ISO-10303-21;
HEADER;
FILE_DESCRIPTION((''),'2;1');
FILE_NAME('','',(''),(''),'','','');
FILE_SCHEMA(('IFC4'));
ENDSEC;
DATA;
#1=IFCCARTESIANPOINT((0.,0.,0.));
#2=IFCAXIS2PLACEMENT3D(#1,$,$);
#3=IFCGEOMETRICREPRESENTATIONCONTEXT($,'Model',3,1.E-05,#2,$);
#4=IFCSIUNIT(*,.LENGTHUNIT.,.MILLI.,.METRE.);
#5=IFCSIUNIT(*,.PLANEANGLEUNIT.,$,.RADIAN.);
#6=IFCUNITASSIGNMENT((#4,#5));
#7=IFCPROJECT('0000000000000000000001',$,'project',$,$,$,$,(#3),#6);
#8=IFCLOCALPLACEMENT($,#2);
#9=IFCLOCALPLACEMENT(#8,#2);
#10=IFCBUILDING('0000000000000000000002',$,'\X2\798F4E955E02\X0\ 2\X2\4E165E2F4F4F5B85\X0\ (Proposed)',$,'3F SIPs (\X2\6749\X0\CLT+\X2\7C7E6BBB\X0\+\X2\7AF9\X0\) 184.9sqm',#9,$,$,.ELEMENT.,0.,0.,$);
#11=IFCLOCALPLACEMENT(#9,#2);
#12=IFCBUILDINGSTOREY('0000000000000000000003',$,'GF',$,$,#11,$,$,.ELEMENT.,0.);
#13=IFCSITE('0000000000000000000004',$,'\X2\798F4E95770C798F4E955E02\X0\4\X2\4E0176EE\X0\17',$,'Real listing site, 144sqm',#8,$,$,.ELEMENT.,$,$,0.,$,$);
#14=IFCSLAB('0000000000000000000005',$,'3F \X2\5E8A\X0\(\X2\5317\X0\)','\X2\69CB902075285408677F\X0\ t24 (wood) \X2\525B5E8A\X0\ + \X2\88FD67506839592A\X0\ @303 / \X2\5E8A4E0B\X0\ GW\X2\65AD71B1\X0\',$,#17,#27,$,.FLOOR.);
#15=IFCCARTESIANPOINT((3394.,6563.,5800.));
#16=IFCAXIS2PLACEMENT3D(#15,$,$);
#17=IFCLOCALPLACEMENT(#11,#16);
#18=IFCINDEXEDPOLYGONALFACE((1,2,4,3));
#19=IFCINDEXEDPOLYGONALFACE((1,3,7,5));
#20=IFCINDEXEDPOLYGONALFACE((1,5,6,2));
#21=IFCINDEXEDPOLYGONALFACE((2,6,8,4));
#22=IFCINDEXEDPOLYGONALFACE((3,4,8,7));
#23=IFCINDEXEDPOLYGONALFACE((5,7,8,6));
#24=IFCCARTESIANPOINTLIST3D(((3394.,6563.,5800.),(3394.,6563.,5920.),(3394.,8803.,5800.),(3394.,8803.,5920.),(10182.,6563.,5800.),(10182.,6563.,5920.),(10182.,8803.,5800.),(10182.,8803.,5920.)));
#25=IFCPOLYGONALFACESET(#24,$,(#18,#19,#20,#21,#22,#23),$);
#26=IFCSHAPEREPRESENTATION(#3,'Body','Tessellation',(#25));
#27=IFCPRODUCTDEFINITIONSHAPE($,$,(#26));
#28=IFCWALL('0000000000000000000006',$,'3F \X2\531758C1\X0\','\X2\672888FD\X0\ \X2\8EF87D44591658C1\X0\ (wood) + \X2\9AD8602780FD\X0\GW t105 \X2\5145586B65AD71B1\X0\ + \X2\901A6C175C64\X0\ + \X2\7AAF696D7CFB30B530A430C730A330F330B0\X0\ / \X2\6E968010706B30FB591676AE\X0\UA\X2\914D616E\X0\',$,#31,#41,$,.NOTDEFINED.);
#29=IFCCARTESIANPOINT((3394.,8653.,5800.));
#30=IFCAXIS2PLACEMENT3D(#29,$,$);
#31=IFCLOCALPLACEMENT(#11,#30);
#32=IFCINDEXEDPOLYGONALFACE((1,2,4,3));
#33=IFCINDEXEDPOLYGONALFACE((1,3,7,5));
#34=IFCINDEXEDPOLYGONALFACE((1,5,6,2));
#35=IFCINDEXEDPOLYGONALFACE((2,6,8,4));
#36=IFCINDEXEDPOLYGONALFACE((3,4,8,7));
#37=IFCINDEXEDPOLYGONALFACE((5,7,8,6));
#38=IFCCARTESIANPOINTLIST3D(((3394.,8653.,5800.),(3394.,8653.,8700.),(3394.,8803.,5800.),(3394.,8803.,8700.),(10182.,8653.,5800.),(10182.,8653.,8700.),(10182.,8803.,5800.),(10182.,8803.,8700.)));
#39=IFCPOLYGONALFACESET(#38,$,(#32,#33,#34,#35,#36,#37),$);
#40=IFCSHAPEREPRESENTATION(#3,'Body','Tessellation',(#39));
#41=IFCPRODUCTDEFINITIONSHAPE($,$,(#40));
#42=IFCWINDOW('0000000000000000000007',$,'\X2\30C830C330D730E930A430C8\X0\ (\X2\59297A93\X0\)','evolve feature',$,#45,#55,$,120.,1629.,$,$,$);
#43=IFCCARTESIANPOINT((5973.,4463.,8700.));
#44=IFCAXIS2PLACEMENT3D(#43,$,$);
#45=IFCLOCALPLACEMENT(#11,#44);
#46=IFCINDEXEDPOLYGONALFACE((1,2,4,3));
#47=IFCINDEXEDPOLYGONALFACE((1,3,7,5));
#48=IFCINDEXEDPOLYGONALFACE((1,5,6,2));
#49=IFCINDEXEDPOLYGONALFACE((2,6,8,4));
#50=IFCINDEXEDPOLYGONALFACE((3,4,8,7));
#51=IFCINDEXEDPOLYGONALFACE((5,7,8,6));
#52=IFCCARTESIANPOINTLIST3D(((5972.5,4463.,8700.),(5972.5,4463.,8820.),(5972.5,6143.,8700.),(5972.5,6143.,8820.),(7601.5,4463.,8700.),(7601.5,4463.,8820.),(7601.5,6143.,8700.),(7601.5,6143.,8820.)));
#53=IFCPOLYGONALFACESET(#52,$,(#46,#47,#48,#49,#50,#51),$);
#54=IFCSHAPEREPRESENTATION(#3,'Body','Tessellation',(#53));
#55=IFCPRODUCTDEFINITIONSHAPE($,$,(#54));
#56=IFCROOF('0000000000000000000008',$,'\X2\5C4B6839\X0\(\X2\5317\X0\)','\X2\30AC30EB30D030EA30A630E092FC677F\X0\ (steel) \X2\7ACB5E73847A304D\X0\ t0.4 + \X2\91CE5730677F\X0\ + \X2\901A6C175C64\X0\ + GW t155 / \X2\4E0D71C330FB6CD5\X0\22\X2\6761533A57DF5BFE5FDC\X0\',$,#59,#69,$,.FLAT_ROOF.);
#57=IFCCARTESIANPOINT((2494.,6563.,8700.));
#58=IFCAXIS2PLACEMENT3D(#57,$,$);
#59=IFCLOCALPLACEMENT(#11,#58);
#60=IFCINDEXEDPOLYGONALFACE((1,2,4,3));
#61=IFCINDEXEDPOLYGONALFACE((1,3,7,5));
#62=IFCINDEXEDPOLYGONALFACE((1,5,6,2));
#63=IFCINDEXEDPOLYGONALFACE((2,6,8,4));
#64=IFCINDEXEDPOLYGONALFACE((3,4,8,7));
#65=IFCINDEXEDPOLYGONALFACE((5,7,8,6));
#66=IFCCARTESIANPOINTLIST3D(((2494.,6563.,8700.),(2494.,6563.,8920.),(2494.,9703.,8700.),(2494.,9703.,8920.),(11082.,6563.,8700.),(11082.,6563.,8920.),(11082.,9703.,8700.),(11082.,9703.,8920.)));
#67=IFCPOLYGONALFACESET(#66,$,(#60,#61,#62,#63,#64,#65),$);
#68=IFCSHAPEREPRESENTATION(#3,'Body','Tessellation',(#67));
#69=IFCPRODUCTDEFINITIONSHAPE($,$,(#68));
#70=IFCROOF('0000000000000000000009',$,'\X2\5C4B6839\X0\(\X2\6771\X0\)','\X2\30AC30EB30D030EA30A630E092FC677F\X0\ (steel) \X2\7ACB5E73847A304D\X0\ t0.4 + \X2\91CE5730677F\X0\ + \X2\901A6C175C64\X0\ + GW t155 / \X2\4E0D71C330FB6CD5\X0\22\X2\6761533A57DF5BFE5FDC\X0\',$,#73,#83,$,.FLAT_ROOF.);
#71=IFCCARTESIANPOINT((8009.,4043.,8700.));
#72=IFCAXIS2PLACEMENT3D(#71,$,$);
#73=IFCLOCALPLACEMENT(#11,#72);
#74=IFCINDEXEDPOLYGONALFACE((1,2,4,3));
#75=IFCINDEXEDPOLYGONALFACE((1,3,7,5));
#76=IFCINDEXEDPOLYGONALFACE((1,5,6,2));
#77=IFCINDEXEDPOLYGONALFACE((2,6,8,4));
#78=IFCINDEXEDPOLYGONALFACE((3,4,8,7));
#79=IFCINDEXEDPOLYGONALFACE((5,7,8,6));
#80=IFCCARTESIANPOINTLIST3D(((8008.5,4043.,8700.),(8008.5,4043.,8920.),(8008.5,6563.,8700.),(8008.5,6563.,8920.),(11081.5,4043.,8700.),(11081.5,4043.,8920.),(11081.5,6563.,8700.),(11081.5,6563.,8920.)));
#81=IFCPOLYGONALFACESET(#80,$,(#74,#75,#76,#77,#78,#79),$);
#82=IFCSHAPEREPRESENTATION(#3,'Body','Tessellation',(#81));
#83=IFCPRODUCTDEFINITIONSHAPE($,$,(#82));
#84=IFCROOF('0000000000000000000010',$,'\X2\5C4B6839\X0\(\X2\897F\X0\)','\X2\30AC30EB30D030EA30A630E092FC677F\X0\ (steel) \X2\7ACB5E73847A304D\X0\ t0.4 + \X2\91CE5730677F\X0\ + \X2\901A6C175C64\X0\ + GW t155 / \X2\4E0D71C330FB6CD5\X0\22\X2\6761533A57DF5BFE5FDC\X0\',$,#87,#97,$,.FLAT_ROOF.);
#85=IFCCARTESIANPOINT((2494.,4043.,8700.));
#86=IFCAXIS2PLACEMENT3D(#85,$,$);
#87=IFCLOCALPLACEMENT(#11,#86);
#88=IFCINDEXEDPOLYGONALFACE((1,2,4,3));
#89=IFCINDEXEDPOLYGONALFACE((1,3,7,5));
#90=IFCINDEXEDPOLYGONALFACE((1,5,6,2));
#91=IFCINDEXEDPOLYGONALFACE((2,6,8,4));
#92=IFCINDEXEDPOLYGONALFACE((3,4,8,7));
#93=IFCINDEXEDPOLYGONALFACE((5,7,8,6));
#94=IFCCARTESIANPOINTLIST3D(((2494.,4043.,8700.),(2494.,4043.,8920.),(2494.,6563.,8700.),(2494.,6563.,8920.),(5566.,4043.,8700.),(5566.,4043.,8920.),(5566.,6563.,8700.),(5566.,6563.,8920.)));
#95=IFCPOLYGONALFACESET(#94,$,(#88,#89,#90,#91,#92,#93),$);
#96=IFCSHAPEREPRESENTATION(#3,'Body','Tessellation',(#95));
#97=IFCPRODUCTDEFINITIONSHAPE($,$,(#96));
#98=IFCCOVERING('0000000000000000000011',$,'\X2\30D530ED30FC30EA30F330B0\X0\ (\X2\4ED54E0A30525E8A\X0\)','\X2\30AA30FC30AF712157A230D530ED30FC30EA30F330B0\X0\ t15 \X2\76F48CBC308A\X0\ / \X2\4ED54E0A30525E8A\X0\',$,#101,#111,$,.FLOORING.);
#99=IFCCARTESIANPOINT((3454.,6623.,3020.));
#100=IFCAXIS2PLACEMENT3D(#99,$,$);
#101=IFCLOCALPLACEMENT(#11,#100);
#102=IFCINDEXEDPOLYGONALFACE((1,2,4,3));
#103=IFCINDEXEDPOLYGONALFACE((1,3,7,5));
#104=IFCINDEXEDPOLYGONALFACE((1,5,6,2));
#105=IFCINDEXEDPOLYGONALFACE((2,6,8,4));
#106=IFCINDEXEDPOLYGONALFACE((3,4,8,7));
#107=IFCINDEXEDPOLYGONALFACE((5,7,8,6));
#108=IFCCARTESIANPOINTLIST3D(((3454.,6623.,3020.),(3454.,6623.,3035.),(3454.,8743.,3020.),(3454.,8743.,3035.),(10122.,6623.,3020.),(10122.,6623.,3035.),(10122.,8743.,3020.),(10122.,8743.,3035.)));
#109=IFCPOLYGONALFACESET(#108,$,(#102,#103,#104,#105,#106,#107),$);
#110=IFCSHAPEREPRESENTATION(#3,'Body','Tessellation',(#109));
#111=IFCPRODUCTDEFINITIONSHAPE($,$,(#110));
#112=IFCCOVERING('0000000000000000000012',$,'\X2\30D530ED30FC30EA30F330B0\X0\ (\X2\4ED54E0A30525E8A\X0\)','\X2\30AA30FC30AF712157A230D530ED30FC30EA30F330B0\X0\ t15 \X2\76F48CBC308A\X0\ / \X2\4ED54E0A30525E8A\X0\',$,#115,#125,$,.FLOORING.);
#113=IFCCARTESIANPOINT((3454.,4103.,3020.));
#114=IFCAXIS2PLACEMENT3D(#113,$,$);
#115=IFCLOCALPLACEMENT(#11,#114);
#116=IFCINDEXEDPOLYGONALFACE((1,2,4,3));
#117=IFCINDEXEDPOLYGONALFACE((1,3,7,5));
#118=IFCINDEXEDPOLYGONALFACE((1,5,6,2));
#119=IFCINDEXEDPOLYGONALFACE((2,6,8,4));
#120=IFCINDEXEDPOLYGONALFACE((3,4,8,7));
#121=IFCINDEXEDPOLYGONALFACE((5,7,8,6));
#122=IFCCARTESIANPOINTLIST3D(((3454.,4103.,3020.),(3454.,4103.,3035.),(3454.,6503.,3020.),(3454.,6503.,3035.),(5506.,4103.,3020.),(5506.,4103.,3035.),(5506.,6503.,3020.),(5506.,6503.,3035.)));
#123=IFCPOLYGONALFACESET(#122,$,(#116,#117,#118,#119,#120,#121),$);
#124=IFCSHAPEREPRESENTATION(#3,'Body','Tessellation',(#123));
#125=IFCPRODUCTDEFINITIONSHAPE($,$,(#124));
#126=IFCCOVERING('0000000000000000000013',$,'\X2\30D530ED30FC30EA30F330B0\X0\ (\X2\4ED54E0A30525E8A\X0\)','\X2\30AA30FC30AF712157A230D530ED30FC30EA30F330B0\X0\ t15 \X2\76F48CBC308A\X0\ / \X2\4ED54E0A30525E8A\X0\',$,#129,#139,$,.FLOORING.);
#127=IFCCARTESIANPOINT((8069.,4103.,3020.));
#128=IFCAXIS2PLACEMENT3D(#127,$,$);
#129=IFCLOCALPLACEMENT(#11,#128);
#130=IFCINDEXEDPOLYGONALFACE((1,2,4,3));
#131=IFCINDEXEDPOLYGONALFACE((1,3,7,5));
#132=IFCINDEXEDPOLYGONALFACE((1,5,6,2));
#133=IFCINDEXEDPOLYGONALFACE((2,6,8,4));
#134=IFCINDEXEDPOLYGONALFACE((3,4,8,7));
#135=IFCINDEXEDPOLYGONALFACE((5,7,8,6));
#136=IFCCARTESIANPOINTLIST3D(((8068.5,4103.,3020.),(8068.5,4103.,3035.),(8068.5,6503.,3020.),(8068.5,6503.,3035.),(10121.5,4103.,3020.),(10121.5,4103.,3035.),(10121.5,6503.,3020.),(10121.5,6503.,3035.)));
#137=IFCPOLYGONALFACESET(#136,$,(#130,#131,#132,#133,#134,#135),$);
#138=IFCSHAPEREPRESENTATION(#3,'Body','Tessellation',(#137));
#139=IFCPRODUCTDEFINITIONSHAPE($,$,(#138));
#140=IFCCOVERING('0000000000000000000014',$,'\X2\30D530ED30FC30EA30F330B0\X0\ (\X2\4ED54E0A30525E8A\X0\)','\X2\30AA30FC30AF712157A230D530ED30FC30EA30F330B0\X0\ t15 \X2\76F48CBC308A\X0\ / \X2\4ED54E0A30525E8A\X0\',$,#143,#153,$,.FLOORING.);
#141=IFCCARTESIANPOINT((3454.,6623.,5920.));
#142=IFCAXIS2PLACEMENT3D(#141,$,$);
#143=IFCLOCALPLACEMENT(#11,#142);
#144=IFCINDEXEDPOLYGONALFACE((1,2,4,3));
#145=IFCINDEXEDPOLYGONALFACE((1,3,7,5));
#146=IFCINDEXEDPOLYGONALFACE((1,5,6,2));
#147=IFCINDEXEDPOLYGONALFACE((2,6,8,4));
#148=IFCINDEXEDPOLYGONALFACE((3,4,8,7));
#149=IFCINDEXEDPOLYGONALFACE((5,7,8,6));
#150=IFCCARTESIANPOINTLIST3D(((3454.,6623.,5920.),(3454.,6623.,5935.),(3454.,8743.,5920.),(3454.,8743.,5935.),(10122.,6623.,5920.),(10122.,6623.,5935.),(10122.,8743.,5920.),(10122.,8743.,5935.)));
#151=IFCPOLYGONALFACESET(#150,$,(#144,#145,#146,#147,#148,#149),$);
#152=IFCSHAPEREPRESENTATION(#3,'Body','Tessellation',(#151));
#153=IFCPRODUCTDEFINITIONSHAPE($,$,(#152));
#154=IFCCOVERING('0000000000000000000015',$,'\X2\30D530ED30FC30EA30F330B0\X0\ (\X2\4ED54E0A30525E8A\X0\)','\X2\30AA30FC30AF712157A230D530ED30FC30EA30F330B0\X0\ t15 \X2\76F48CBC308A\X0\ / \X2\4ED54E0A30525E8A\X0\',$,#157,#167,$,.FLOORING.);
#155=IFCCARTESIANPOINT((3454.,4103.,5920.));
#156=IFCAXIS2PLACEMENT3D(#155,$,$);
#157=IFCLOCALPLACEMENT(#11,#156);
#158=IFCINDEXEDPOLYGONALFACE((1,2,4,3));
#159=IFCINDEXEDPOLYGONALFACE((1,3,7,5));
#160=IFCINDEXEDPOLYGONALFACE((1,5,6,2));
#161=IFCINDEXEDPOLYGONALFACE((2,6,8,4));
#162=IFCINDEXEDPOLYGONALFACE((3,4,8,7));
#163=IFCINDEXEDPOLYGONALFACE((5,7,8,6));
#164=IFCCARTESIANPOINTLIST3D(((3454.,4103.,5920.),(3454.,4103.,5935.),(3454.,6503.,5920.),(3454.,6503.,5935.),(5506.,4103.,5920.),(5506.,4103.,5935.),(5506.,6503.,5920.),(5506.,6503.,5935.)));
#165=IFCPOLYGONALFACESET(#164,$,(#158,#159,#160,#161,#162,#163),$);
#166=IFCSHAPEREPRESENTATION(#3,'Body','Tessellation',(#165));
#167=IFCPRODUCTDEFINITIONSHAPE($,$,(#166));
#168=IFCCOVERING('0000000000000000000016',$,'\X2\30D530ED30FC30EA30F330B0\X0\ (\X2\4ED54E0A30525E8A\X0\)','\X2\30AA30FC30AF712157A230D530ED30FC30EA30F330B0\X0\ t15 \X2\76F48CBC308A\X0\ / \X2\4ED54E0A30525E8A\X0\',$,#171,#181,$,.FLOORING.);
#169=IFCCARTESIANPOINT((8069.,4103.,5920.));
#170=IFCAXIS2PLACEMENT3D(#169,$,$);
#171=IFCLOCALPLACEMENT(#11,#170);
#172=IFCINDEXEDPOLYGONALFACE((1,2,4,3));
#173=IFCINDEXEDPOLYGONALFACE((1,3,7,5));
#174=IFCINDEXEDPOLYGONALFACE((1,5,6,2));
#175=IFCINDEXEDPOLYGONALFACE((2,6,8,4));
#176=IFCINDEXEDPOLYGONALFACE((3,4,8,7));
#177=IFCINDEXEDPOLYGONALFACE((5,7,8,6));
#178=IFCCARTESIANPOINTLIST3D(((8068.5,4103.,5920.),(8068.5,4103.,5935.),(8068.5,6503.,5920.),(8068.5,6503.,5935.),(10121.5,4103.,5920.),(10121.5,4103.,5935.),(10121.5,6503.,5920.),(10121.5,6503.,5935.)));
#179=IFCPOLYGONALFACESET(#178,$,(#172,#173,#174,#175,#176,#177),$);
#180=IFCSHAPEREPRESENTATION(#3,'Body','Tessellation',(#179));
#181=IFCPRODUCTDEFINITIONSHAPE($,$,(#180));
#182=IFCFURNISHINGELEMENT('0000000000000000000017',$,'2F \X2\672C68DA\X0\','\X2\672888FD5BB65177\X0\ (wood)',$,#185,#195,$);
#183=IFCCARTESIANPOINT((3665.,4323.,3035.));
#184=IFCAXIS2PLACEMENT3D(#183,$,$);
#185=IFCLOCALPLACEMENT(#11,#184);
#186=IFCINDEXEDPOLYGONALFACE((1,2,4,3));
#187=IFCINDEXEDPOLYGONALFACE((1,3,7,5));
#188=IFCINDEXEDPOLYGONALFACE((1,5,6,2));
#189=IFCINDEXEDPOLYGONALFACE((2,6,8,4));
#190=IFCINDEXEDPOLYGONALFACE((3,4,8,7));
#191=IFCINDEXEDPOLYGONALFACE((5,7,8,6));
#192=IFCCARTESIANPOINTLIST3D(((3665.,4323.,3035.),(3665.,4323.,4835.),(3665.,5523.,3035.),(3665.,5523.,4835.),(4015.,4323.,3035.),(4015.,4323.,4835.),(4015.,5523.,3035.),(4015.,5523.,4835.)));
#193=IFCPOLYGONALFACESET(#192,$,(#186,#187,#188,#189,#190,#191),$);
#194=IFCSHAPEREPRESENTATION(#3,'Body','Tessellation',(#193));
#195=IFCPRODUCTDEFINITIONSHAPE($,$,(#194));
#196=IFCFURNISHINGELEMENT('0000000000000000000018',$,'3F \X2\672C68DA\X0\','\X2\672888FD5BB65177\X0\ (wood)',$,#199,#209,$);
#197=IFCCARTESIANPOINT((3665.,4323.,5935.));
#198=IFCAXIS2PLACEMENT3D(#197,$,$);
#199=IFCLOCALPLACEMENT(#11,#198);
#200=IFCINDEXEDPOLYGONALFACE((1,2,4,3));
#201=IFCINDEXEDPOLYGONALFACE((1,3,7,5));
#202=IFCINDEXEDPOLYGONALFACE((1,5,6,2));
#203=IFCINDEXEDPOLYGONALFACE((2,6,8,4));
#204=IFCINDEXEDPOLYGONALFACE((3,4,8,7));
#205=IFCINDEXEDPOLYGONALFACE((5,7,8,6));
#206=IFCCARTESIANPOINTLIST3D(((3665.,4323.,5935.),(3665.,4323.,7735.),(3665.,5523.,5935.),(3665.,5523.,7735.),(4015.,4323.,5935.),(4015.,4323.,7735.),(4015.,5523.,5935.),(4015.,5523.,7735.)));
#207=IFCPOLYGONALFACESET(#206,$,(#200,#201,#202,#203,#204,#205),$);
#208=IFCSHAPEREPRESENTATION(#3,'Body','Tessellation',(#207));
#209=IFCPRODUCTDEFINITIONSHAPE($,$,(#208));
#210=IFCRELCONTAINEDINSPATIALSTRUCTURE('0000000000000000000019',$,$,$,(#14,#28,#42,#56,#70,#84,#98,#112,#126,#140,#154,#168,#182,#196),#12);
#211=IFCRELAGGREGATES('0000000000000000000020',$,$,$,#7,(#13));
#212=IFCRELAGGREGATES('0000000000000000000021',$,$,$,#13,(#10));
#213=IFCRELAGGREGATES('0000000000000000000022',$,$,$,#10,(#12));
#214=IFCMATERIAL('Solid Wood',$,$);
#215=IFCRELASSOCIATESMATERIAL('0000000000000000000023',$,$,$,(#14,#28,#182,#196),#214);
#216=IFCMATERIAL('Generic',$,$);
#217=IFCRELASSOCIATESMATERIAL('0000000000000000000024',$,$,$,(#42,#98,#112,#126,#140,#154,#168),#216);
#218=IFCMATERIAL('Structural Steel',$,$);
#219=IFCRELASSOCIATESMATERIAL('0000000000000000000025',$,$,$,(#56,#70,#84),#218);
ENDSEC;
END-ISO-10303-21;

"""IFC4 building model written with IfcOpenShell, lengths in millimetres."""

from ifc_helpers import new_model, si_unit, frame, frame_2d, origin, place, context, project, spatial, rectangle, extrude, material, element, save


model = new_model("IFC4")

# Units and contexts
model_context = context("Model", 3, precision=1e-05, world=origin())
ifc_project = project(units=[si_unit("LENGTHUNIT", "METRE", prefix="MILLI"), si_unit("PLANEANGLEUNIT", "RADIAN")], contexts=[model_context])

# Site, building, storey
site_placement = place(None, origin())
site = spatial("IfcSite", under=ifc_project, at=site_placement, Name="福井県福井市4丁目17", ObjectType="Real listing site, 144sqm", CompositionType="ELEMENT", RefElevation=0.0)
building_placement = place(site_placement, origin())
building = spatial("IfcBuilding", under=site, at=building_placement, Name="福井市 2世帯住宅 (Proposed)", ObjectType="3F SIPs (杉CLT+籾殻+竹) 184.9sqm", CompositionType="ELEMENT", ElevationOfRefHeight=0.0, ElevationOfTerrain=0.0)
storey_placement = place(building_placement, origin())
storey = spatial("IfcBuildingStorey", under=building, at=storey_placement, Name="GF", CompositionType="ELEMENT", Elevation=0.0)

# Slab
ifc_material_1 = material(Name="Solid Wood")
slab_placement = place(storey_placement, frame((3394.0, 6563.0, 5800.0)))
element("IfcSlab", 1, at=slab_placement, inside=storey, material=ifc_material_1, Name="3F 床(北)", Description="構造用合板 t24 (wood) 剛床 + 製材根太 @303 / 床下 GW断熱", PredefinedType="FLOOR", context=model_context, shape_type="SweptSolid", body=[
    extrude(rectangle(XDim=6788.0, YDim=2240.0, at=frame_2d((3394.0, 1120.0))), frame((3394.0, 6563.0, 5800.0)), (0.0, 0.0, 1.0), 120.0),
])

# Wall
wall_1_placement = place(storey_placement, frame((3394.0, 8653.0, 5800.0)))
element("IfcWall", 2, at=wall_1_placement, inside=storey, material=ifc_material_1, Name="3F 北壁", Description="木製 軸組外壁 (wood) + 高性能GW t105 充填断熱 + 通気層 + 窯業系サイディング / 準耐火・外皮UA配慮", PredefinedType="NOTDEFINED", context=model_context, shape_type="SweptSolid", body=[
    extrude(rectangle(XDim=6788.0, YDim=150.0, at=frame_2d((3394.0, 75.0))), frame((3394.0, 8653.0, 5800.0)), (0.0, 0.0, 1.0), 2900.0),
])

# Window
ifc_material_2 = material(Name="Generic")
window_1_placement = place(storey_placement, frame((5973.0, 4463.0, 8700.0)))
element("IfcWindow", 3, at=window_1_placement, inside=storey, material=ifc_material_2, Name="トップライト (天窓)", Description="evolve feature", OverallHeight=120.0, OverallWidth=1629.0, context=model_context, shape_type="SweptSolid", body=[
    extrude(rectangle(XDim=1629.0, YDim=1680.0, at=frame_2d((814.0, 840.0))), frame((5973.0, 4463.0, 8700.0)), (0.0, 0.0, 1.0), 120.0),
])

# Roofs
ifc_material_3 = material(Name="Structural Steel")
roof_1_placement = place(storey_placement, frame((2494.0, 6563.0, 8700.0)))
element("IfcRoof", 4, at=roof_1_placement, inside=storey, material=ifc_material_3, Name="屋根(北)", Description="ガルバリウム鋼板 (steel) 立平葺き t0.4 + 野地板 + 通気層 + GW t155 / 不燃・法22条区域対応", PredefinedType="FLAT_ROOF", context=model_context, shape_type="SweptSolid", body=[
    extrude(rectangle(XDim=8588.0, YDim=3140.0, at=frame_2d((4294.0, 1570.0))), frame((2494.0, 6563.0, 8700.0)), (0.0, 0.0, 1.0), 220.0),
])
roof_2_placement = place(storey_placement, frame((8009.0, 4043.0, 8700.0)))
element("IfcRoof", 5, at=roof_2_placement, inside=storey, material=ifc_material_3, Name="屋根(東)", Description="ガルバリウム鋼板 (steel) 立平葺き t0.4 + 野地板 + 通気層 + GW t155 / 不燃・法22条区域対応", PredefinedType="FLAT_ROOF", context=model_context, shape_type="SweptSolid", body=[
    extrude(rectangle(XDim=3073.0, YDim=2520.0, at=frame_2d((1536.0, 1260.0))), frame((8009.0, 4043.0, 8700.0)), (0.0, 0.0, 1.0), 220.0),
])
roof_3_placement = place(storey_placement, frame((2494.0, 4043.0, 8700.0)))
element("IfcRoof", 6, at=roof_3_placement, inside=storey, material=ifc_material_3, Name="屋根(西)", Description="ガルバリウム鋼板 (steel) 立平葺き t0.4 + 野地板 + 通気層 + GW t155 / 不燃・法22条区域対応", PredefinedType="FLAT_ROOF", context=model_context, shape_type="SweptSolid", body=[
    extrude(rectangle(XDim=3072.0, YDim=2520.0, at=frame_2d((1536.0, 1260.0))), frame((2494.0, 4043.0, 8700.0)), (0.0, 0.0, 1.0), 220.0),
])

# Coverings
covering_1_placement = place(storey_placement, frame((3454.0, 6623.0, 3020.0)))
element("IfcCovering", 7, at=covering_1_placement, inside=storey, material=ifc_material_2, Name="フローリング (仕上げ床)", Description="オーク無垢フローリング t15 直貼り / 仕上げ床", PredefinedType="FLOORING", context=model_context, shape_type="SweptSolid", body=[
    extrude(rectangle(XDim=6668.0, YDim=2120.0, at=frame_2d((3334.0, 1060.0))), frame((3454.0, 6623.0, 3020.0)), (0.0, 0.0, 1.0), 15.0),
])
covering_2_placement = place(storey_placement, frame((3454.0, 4103.0, 3020.0)))
element("IfcCovering", 8, at=covering_2_placement, inside=storey, material=ifc_material_2, Name="フローリング (仕上げ床)", Description="オーク無垢フローリング t15 直貼り / 仕上げ床", PredefinedType="FLOORING", context=model_context, shape_type="SweptSolid", body=[
    extrude(rectangle(XDim=2052.0, YDim=2400.0, at=frame_2d((1026.0, 1200.0))), frame((3454.0, 4103.0, 3020.0)), (0.0, 0.0, 1.0), 15.0),
])
covering_3_placement = place(storey_placement, frame((8069.0, 4103.0, 3020.0)))
element("IfcCovering", 9, at=covering_3_placement, inside=storey, material=ifc_material_2, Name="フローリング (仕上げ床)", Description="オーク無垢フローリング t15 直貼り / 仕上げ床", PredefinedType="FLOORING", context=model_context, shape_type="SweptSolid", body=[
    extrude(rectangle(XDim=2053.0, YDim=2400.0, at=frame_2d((1026.0, 1200.0))), frame((8069.0, 4103.0, 3020.0)), (0.0, 0.0, 1.0), 15.0),
])
covering_4_placement = place(storey_placement, frame((3454.0, 6623.0, 5920.0)))
element("IfcCovering", 10, at=covering_4_placement, inside=storey, material=ifc_material_2, Name="フローリング (仕上げ床)", Description="オーク無垢フローリング t15 直貼り / 仕上げ床", PredefinedType="FLOORING", context=model_context, shape_type="SweptSolid", body=[
    extrude(rectangle(XDim=6668.0, YDim=2120.0, at=frame_2d((3334.0, 1060.0))), frame((3454.0, 6623.0, 5920.0)), (0.0, 0.0, 1.0), 15.0),
])
covering_5_placement = place(storey_placement, frame((3454.0, 4103.0, 5920.0)))
element("IfcCovering", 11, at=covering_5_placement, inside=storey, material=ifc_material_2, Name="フローリング (仕上げ床)", Description="オーク無垢フローリング t15 直貼り / 仕上げ床", PredefinedType="FLOORING", context=model_context, shape_type="SweptSolid", body=[
    extrude(rectangle(XDim=2052.0, YDim=2400.0, at=frame_2d((1026.0, 1200.0))), frame((3454.0, 4103.0, 5920.0)), (0.0, 0.0, 1.0), 15.0),
])
covering_6_placement = place(storey_placement, frame((8069.0, 4103.0, 5920.0)))
element("IfcCovering", 12, at=covering_6_placement, inside=storey, material=ifc_material_2, Name="フローリング (仕上げ床)", Description="オーク無垢フローリング t15 直貼り / 仕上げ床", PredefinedType="FLOORING", context=model_context, shape_type="SweptSolid", body=[
    extrude(rectangle(XDim=2053.0, YDim=2400.0, at=frame_2d((1026.0, 1200.0))), frame((8069.0, 4103.0, 5920.0)), (0.0, 0.0, 1.0), 15.0),
])

# Furnishing elements
furnishing_1_placement = place(storey_placement, frame((3665.0, 4323.0, 3035.0)))
element("IfcFurnishingElement", 13, at=furnishing_1_placement, inside=storey, material=ifc_material_1, Name="2F 本棚", Description="木製家具 (wood)", context=model_context, shape_type="SweptSolid", body=[
    extrude(rectangle(XDim=350.0, YDim=1200.0, at=frame_2d((175.0, 600.0))), frame((3665.0, 4323.0, 3035.0)), (0.0, 0.0, 1.0), 1800.0),
])
furnishing_2_placement = place(storey_placement, frame((3665.0, 4323.0, 5935.0)))
element("IfcFurnishingElement", 14, at=furnishing_2_placement, inside=storey, material=ifc_material_1, Name="3F 本棚", Description="木製家具 (wood)", context=model_context, shape_type="SweptSolid", body=[
    extrude(rectangle(XDim=350.0, YDim=1200.0, at=frame_2d((175.0, 600.0))), frame((3665.0, 4323.0, 5935.0)), (0.0, 0.0, 1.0), 1800.0),
])

save(model, "model.ifc")
